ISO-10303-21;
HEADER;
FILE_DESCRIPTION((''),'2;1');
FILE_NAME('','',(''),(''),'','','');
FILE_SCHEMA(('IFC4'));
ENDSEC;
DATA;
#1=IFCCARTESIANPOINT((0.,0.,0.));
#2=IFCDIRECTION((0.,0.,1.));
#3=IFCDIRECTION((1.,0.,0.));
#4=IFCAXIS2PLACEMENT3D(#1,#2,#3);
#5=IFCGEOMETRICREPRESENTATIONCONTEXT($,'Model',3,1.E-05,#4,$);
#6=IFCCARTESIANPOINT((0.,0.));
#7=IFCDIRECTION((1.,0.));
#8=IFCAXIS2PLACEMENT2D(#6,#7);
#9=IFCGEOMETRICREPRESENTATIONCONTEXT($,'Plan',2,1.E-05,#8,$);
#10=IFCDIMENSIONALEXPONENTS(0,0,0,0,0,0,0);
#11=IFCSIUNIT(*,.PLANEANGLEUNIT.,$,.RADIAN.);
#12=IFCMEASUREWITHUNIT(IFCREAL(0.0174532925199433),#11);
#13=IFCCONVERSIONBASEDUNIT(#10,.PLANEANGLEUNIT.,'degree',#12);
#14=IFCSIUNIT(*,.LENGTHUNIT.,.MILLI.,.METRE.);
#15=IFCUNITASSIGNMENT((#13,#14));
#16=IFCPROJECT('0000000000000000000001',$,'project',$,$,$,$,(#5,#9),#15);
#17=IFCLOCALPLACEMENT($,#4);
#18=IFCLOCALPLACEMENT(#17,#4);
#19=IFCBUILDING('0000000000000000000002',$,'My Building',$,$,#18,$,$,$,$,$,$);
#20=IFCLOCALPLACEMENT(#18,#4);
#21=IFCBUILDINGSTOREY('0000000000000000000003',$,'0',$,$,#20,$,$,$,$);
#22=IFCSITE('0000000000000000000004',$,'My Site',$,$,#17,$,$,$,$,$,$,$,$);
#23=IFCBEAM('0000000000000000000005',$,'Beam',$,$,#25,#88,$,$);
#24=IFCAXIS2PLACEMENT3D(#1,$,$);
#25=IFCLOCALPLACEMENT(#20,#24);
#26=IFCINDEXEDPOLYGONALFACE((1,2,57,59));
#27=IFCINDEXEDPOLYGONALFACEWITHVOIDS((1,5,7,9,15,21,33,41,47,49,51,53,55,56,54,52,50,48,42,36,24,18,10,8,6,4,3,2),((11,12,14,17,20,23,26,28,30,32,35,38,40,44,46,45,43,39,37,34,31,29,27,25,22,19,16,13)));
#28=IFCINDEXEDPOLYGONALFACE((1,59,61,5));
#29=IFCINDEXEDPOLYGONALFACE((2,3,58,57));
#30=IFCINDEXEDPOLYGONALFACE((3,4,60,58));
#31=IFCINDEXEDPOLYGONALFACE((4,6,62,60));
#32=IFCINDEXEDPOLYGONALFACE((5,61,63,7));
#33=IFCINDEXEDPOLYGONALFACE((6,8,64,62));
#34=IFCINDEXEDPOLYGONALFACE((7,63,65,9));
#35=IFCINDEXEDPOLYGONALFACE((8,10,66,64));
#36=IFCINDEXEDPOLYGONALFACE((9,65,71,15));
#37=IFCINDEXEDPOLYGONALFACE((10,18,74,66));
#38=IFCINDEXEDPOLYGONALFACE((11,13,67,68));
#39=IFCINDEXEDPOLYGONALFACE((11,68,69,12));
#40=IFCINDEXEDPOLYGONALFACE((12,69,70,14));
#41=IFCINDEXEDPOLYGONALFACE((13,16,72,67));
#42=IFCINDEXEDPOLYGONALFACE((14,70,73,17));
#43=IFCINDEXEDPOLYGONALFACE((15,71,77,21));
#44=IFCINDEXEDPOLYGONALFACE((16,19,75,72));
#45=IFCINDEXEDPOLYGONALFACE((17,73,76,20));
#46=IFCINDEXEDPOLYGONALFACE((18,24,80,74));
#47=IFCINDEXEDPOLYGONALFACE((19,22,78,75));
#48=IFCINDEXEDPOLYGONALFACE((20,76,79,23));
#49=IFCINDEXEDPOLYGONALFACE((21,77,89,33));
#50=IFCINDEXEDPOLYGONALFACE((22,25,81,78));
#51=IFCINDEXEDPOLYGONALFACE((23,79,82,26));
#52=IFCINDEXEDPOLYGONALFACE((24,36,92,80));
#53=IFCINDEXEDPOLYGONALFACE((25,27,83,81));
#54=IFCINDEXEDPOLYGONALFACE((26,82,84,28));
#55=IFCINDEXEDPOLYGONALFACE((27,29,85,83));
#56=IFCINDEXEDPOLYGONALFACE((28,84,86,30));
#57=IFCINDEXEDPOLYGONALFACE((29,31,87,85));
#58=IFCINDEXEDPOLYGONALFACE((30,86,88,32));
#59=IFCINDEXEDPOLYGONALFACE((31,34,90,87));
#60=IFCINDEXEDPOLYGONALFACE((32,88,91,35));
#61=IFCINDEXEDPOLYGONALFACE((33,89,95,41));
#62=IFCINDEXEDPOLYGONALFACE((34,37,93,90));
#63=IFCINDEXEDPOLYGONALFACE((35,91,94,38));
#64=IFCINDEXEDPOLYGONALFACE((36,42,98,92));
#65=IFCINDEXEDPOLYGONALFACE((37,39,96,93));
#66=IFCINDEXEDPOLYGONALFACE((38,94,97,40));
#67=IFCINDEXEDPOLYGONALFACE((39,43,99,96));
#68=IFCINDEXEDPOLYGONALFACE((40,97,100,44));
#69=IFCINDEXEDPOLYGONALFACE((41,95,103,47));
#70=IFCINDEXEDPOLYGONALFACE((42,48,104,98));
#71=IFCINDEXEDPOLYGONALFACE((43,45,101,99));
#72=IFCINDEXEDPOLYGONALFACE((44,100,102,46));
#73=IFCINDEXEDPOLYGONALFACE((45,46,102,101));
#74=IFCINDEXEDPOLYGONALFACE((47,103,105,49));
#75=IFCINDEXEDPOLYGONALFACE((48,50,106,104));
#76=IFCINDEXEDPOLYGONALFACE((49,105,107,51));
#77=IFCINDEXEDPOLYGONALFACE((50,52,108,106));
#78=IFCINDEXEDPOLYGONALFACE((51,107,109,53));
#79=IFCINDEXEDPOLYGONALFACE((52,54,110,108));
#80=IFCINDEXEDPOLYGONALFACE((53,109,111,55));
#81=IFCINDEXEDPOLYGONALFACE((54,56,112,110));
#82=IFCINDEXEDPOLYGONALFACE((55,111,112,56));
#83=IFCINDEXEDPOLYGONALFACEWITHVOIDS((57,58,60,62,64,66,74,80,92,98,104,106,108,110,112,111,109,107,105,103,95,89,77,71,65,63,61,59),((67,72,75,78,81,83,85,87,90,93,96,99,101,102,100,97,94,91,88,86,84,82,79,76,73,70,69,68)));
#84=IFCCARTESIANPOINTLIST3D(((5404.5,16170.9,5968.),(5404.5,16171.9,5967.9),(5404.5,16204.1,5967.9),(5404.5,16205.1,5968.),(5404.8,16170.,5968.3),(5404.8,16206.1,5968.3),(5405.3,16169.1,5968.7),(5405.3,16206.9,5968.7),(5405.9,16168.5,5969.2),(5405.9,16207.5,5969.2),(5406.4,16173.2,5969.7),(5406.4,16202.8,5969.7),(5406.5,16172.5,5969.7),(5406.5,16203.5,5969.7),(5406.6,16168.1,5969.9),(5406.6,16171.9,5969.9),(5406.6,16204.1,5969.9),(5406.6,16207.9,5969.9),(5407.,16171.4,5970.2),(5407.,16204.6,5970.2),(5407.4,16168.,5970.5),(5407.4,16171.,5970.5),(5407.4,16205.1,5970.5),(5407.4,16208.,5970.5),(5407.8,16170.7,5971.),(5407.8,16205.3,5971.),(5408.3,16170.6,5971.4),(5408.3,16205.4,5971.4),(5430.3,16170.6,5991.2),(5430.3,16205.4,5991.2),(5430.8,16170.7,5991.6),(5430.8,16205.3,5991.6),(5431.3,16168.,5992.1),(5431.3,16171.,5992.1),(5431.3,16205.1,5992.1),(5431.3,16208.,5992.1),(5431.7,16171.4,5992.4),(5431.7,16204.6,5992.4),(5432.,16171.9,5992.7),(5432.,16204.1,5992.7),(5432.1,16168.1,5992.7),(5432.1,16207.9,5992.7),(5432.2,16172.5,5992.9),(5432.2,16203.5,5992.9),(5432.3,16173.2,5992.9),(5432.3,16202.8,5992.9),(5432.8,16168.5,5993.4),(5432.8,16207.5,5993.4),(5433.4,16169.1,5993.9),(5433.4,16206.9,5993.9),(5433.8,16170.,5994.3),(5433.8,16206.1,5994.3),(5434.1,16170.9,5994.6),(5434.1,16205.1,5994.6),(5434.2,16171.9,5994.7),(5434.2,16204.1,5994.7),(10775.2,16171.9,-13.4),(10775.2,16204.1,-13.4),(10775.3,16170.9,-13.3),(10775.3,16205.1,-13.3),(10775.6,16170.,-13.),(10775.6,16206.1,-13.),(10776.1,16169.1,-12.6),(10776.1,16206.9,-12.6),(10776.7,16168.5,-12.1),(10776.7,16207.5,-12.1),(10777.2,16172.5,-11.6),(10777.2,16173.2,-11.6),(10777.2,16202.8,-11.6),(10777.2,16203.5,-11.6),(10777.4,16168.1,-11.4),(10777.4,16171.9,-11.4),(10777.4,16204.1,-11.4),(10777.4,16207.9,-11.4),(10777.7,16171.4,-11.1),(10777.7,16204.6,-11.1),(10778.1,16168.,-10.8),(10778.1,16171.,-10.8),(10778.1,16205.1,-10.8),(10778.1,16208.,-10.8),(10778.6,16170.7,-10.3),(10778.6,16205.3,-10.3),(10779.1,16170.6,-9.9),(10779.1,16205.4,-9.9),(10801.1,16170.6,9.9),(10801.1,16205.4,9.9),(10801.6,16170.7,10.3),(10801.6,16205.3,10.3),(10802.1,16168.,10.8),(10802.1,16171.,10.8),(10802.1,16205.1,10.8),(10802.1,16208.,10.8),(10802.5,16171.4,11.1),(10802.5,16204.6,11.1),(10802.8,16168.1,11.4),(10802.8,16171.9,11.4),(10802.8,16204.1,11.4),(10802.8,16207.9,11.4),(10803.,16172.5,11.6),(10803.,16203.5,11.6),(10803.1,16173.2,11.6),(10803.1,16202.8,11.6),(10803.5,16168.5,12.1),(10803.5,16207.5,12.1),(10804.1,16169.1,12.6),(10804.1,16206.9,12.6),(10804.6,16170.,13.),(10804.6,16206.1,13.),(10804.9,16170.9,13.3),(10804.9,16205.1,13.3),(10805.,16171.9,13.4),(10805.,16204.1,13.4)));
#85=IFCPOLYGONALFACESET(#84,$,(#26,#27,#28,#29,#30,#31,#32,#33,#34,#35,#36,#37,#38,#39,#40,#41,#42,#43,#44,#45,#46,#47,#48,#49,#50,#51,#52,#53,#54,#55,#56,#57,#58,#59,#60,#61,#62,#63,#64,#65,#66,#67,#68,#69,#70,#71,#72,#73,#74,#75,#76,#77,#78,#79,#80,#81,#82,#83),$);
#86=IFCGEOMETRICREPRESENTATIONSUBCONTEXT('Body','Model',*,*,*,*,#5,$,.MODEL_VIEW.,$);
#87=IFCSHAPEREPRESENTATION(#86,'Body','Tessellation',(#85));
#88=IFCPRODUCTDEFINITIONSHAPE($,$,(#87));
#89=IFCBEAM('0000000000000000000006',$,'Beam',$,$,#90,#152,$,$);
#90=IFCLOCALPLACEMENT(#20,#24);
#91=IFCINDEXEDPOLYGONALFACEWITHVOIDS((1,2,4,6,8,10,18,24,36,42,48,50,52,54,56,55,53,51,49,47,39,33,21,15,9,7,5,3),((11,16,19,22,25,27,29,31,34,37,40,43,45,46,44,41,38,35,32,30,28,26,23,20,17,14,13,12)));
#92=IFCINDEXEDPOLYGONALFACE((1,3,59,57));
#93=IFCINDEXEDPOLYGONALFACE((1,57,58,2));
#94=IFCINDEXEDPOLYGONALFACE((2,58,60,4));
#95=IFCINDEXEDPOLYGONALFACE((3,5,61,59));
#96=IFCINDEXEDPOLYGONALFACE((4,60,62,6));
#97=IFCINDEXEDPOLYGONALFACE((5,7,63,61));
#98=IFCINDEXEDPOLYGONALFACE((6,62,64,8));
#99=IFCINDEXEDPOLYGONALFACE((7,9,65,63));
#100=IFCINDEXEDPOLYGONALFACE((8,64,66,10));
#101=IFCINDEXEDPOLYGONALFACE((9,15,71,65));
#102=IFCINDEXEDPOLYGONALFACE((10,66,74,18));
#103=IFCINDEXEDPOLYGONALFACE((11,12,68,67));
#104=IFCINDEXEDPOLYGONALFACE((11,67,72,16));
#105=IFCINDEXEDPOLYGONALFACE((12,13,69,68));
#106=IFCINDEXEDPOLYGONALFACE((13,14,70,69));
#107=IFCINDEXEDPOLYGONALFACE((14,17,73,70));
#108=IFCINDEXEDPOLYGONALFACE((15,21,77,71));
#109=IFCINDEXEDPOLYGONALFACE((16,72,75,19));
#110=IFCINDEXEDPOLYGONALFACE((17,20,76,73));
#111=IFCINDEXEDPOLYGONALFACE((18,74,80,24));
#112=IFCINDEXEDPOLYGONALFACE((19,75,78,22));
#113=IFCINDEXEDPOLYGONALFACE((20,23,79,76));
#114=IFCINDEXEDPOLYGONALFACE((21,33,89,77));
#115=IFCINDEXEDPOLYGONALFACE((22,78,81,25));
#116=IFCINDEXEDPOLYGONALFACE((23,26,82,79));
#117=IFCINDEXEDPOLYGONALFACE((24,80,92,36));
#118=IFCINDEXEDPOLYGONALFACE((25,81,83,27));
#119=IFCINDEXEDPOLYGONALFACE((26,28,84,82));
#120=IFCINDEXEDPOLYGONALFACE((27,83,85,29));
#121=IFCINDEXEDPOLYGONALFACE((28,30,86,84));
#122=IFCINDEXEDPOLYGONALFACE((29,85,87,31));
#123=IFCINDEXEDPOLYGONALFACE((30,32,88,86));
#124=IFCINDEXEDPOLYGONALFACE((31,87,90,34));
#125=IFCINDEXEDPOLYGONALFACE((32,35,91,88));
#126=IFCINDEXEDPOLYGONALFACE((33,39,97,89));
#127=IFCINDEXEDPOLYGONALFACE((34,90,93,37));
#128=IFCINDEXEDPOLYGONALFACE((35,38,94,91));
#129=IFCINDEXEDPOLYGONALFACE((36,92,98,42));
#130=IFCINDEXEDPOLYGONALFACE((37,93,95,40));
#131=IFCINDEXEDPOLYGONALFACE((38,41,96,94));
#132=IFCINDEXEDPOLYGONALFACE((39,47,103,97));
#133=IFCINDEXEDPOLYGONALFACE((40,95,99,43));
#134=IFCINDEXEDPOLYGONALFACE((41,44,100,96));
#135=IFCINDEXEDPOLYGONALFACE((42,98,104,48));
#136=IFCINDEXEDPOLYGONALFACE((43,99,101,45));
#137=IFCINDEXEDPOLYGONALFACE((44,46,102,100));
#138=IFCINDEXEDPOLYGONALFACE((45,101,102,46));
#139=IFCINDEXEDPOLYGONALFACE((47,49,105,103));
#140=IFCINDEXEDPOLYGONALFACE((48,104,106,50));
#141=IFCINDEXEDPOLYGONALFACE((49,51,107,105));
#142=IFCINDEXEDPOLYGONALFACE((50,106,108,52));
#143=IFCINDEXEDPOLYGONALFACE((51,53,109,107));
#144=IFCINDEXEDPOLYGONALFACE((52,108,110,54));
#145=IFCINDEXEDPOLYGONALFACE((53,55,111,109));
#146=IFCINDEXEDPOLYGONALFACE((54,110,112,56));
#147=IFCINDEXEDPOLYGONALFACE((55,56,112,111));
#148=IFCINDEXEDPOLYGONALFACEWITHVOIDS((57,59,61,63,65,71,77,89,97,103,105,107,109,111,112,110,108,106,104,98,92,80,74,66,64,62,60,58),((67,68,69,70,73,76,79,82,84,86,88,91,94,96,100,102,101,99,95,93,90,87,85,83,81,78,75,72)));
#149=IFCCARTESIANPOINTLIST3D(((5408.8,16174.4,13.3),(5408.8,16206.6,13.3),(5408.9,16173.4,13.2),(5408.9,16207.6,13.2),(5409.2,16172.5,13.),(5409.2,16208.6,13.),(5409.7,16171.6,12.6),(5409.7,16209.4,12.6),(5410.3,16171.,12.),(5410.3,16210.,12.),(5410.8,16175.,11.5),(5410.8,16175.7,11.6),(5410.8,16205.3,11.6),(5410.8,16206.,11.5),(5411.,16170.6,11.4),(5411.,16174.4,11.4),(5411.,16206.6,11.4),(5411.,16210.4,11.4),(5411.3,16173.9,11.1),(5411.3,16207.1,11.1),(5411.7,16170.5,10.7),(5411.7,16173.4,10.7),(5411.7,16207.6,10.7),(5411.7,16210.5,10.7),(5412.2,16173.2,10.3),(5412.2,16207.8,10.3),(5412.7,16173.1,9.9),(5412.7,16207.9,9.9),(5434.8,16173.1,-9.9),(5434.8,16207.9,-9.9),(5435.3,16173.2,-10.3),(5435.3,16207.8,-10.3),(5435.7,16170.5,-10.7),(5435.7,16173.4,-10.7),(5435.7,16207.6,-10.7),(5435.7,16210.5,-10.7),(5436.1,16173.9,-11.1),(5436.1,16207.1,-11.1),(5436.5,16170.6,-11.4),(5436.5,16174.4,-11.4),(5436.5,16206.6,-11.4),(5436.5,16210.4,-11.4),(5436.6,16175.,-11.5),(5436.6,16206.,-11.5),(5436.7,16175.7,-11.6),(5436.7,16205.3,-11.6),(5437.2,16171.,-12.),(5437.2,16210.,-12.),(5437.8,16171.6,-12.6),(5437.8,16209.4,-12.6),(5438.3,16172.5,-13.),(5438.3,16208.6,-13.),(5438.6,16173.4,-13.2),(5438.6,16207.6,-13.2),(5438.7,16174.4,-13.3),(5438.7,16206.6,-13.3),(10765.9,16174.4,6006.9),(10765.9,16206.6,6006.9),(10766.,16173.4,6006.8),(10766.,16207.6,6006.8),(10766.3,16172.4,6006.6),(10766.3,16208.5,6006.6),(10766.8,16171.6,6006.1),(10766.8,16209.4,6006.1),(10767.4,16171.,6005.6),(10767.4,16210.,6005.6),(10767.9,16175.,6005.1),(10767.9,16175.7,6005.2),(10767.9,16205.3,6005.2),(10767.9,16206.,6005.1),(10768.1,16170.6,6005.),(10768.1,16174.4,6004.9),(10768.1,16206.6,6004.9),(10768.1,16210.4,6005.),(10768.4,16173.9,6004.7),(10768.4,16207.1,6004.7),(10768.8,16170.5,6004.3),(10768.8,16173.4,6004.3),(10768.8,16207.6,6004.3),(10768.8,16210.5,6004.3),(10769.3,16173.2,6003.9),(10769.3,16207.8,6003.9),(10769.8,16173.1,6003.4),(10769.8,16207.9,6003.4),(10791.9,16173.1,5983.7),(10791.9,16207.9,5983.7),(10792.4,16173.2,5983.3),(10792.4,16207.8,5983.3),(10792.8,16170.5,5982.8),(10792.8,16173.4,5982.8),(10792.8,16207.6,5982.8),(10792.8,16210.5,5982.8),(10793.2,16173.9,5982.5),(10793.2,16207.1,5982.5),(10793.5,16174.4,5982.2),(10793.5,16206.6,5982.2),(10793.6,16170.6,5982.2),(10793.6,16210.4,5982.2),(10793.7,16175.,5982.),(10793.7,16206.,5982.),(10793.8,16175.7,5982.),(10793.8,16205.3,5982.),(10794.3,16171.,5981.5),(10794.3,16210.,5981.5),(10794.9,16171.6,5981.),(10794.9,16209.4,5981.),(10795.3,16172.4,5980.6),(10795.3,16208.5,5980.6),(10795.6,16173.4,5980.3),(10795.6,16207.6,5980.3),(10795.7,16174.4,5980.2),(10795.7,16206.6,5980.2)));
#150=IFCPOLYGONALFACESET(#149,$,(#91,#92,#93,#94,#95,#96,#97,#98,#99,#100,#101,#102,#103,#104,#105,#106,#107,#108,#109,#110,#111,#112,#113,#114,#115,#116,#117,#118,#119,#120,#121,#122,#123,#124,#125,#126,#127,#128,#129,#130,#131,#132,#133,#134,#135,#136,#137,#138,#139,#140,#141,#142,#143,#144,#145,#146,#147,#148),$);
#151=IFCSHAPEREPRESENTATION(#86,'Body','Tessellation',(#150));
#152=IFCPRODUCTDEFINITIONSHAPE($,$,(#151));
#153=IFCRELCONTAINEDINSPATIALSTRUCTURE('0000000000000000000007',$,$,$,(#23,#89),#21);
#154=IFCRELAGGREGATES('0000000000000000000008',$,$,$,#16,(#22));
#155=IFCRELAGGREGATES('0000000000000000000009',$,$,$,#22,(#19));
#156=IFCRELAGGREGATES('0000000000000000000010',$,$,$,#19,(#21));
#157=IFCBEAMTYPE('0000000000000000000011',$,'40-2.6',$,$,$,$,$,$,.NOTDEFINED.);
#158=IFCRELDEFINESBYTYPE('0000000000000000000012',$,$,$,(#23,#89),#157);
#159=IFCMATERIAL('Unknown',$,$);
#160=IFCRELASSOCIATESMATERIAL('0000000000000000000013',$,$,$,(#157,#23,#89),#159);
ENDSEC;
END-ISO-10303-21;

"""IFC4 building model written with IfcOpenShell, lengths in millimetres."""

from ifc_helpers import new_model, entity, si_unit, converted_unit, frame, origin_with_axes, origin_2d_with_axis, place, context, subcontext, project, spatial, hollow_rectangle, extrude, material, material_profile, profile_set, profile_usage, type_object, element, save


model = new_model("IFC4")

# Units and contexts
model_context = context("Model", 3, precision=1e-05, world=origin_with_axes())
plan_context = context("Plan", 2, precision=1e-05, world=origin_2d_with_axis())
body_context = subcontext(model_context, "Body", "Model", "MODEL_VIEW")
ifc_project = project(units=[converted_unit("PLANEANGLEUNIT", "degree", entity("IfcReal", 0.0174532925199433), si_unit("PLANEANGLEUNIT", "RADIAN"), dimensions=[0, 0, 0, 0, 0, 0, 0]), si_unit("LENGTHUNIT", "METRE", prefix="MILLI")], contexts=[model_context, plan_context])

# Site, building, storey
site_placement = place(None, origin_with_axes())
site = spatial("IfcSite", under=ifc_project, at=site_placement, Name="My Site")
building_placement = place(site_placement, origin_with_axes())
building = spatial("IfcBuilding", under=site, at=building_placement, Name="My Building")
storey_placement = place(building_placement, origin_with_axes())
storey = spatial("IfcBuildingStorey", under=building, at=storey_placement, Name="0")

# Shared definitions
ifc_material = material(Name="Unknown")

# Beams
ifc_material_profile_1 = material_profile(ifc_material, hollow_rectangle(XDim=40.0, YDim=40.0, WallThickness=2.6, InnerFilletRadius=2.6, OuterFilletRadius=3.9))
ifc_profile_set_1 = profile_set([ifc_material_profile_1])
beam_type = type_object("IfcBeamType", Name="40-2.6", PredefinedType="NOTDEFINED", material=ifc_profile_set_1)
ifc_profile_usage_1 = profile_usage(ifc_profile_set_1, cardinal=5)
beam_1_placement = place(storey_placement, frame((10790.1, 16188.0, 0.0), z_axis=(-0.668113, 0.0, 0.74406), x_axis=(0.0, 1.0, 0.0)))
element("IfcBeam", 1, at=beam_1_placement, inside=storey, type_object=beam_type, material=ifc_profile_usage_1, Name="Beam", context=body_context, shape_type="SweptSolid", body=[
    extrude(hollow_rectangle(XDim=40.0, YDim=40.0, WallThickness=2.6, InnerFilletRadius=2.6, OuterFilletRadius=3.9), origin_with_axes(), (0.0, 0.0, 1.0), 8038.7),
])
ifc_profile_usage_2 = profile_usage(ifc_profile_set_1, cardinal=5)
beam_2_placement = place(storey_placement, frame((5423.7, 16190.5, 0.0), z_axis=(0.666409, 0.0, 0.745587), x_axis=(0.0, 1.0, 0.0)))
element("IfcBeam", 2, at=beam_2_placement, inside=storey, type_object=beam_type, material=ifc_profile_usage_2, Name="Beam", context=body_context, shape_type="SweptSolid", body=[
    extrude(hollow_rectangle(XDim=40.0, YDim=40.0, WallThickness=2.6, InnerFilletRadius=2.6, OuterFilletRadius=3.9), origin_with_axes(), (0.0, 0.0, 1.0), 8038.7),
])

save(model, "model.ifc")
